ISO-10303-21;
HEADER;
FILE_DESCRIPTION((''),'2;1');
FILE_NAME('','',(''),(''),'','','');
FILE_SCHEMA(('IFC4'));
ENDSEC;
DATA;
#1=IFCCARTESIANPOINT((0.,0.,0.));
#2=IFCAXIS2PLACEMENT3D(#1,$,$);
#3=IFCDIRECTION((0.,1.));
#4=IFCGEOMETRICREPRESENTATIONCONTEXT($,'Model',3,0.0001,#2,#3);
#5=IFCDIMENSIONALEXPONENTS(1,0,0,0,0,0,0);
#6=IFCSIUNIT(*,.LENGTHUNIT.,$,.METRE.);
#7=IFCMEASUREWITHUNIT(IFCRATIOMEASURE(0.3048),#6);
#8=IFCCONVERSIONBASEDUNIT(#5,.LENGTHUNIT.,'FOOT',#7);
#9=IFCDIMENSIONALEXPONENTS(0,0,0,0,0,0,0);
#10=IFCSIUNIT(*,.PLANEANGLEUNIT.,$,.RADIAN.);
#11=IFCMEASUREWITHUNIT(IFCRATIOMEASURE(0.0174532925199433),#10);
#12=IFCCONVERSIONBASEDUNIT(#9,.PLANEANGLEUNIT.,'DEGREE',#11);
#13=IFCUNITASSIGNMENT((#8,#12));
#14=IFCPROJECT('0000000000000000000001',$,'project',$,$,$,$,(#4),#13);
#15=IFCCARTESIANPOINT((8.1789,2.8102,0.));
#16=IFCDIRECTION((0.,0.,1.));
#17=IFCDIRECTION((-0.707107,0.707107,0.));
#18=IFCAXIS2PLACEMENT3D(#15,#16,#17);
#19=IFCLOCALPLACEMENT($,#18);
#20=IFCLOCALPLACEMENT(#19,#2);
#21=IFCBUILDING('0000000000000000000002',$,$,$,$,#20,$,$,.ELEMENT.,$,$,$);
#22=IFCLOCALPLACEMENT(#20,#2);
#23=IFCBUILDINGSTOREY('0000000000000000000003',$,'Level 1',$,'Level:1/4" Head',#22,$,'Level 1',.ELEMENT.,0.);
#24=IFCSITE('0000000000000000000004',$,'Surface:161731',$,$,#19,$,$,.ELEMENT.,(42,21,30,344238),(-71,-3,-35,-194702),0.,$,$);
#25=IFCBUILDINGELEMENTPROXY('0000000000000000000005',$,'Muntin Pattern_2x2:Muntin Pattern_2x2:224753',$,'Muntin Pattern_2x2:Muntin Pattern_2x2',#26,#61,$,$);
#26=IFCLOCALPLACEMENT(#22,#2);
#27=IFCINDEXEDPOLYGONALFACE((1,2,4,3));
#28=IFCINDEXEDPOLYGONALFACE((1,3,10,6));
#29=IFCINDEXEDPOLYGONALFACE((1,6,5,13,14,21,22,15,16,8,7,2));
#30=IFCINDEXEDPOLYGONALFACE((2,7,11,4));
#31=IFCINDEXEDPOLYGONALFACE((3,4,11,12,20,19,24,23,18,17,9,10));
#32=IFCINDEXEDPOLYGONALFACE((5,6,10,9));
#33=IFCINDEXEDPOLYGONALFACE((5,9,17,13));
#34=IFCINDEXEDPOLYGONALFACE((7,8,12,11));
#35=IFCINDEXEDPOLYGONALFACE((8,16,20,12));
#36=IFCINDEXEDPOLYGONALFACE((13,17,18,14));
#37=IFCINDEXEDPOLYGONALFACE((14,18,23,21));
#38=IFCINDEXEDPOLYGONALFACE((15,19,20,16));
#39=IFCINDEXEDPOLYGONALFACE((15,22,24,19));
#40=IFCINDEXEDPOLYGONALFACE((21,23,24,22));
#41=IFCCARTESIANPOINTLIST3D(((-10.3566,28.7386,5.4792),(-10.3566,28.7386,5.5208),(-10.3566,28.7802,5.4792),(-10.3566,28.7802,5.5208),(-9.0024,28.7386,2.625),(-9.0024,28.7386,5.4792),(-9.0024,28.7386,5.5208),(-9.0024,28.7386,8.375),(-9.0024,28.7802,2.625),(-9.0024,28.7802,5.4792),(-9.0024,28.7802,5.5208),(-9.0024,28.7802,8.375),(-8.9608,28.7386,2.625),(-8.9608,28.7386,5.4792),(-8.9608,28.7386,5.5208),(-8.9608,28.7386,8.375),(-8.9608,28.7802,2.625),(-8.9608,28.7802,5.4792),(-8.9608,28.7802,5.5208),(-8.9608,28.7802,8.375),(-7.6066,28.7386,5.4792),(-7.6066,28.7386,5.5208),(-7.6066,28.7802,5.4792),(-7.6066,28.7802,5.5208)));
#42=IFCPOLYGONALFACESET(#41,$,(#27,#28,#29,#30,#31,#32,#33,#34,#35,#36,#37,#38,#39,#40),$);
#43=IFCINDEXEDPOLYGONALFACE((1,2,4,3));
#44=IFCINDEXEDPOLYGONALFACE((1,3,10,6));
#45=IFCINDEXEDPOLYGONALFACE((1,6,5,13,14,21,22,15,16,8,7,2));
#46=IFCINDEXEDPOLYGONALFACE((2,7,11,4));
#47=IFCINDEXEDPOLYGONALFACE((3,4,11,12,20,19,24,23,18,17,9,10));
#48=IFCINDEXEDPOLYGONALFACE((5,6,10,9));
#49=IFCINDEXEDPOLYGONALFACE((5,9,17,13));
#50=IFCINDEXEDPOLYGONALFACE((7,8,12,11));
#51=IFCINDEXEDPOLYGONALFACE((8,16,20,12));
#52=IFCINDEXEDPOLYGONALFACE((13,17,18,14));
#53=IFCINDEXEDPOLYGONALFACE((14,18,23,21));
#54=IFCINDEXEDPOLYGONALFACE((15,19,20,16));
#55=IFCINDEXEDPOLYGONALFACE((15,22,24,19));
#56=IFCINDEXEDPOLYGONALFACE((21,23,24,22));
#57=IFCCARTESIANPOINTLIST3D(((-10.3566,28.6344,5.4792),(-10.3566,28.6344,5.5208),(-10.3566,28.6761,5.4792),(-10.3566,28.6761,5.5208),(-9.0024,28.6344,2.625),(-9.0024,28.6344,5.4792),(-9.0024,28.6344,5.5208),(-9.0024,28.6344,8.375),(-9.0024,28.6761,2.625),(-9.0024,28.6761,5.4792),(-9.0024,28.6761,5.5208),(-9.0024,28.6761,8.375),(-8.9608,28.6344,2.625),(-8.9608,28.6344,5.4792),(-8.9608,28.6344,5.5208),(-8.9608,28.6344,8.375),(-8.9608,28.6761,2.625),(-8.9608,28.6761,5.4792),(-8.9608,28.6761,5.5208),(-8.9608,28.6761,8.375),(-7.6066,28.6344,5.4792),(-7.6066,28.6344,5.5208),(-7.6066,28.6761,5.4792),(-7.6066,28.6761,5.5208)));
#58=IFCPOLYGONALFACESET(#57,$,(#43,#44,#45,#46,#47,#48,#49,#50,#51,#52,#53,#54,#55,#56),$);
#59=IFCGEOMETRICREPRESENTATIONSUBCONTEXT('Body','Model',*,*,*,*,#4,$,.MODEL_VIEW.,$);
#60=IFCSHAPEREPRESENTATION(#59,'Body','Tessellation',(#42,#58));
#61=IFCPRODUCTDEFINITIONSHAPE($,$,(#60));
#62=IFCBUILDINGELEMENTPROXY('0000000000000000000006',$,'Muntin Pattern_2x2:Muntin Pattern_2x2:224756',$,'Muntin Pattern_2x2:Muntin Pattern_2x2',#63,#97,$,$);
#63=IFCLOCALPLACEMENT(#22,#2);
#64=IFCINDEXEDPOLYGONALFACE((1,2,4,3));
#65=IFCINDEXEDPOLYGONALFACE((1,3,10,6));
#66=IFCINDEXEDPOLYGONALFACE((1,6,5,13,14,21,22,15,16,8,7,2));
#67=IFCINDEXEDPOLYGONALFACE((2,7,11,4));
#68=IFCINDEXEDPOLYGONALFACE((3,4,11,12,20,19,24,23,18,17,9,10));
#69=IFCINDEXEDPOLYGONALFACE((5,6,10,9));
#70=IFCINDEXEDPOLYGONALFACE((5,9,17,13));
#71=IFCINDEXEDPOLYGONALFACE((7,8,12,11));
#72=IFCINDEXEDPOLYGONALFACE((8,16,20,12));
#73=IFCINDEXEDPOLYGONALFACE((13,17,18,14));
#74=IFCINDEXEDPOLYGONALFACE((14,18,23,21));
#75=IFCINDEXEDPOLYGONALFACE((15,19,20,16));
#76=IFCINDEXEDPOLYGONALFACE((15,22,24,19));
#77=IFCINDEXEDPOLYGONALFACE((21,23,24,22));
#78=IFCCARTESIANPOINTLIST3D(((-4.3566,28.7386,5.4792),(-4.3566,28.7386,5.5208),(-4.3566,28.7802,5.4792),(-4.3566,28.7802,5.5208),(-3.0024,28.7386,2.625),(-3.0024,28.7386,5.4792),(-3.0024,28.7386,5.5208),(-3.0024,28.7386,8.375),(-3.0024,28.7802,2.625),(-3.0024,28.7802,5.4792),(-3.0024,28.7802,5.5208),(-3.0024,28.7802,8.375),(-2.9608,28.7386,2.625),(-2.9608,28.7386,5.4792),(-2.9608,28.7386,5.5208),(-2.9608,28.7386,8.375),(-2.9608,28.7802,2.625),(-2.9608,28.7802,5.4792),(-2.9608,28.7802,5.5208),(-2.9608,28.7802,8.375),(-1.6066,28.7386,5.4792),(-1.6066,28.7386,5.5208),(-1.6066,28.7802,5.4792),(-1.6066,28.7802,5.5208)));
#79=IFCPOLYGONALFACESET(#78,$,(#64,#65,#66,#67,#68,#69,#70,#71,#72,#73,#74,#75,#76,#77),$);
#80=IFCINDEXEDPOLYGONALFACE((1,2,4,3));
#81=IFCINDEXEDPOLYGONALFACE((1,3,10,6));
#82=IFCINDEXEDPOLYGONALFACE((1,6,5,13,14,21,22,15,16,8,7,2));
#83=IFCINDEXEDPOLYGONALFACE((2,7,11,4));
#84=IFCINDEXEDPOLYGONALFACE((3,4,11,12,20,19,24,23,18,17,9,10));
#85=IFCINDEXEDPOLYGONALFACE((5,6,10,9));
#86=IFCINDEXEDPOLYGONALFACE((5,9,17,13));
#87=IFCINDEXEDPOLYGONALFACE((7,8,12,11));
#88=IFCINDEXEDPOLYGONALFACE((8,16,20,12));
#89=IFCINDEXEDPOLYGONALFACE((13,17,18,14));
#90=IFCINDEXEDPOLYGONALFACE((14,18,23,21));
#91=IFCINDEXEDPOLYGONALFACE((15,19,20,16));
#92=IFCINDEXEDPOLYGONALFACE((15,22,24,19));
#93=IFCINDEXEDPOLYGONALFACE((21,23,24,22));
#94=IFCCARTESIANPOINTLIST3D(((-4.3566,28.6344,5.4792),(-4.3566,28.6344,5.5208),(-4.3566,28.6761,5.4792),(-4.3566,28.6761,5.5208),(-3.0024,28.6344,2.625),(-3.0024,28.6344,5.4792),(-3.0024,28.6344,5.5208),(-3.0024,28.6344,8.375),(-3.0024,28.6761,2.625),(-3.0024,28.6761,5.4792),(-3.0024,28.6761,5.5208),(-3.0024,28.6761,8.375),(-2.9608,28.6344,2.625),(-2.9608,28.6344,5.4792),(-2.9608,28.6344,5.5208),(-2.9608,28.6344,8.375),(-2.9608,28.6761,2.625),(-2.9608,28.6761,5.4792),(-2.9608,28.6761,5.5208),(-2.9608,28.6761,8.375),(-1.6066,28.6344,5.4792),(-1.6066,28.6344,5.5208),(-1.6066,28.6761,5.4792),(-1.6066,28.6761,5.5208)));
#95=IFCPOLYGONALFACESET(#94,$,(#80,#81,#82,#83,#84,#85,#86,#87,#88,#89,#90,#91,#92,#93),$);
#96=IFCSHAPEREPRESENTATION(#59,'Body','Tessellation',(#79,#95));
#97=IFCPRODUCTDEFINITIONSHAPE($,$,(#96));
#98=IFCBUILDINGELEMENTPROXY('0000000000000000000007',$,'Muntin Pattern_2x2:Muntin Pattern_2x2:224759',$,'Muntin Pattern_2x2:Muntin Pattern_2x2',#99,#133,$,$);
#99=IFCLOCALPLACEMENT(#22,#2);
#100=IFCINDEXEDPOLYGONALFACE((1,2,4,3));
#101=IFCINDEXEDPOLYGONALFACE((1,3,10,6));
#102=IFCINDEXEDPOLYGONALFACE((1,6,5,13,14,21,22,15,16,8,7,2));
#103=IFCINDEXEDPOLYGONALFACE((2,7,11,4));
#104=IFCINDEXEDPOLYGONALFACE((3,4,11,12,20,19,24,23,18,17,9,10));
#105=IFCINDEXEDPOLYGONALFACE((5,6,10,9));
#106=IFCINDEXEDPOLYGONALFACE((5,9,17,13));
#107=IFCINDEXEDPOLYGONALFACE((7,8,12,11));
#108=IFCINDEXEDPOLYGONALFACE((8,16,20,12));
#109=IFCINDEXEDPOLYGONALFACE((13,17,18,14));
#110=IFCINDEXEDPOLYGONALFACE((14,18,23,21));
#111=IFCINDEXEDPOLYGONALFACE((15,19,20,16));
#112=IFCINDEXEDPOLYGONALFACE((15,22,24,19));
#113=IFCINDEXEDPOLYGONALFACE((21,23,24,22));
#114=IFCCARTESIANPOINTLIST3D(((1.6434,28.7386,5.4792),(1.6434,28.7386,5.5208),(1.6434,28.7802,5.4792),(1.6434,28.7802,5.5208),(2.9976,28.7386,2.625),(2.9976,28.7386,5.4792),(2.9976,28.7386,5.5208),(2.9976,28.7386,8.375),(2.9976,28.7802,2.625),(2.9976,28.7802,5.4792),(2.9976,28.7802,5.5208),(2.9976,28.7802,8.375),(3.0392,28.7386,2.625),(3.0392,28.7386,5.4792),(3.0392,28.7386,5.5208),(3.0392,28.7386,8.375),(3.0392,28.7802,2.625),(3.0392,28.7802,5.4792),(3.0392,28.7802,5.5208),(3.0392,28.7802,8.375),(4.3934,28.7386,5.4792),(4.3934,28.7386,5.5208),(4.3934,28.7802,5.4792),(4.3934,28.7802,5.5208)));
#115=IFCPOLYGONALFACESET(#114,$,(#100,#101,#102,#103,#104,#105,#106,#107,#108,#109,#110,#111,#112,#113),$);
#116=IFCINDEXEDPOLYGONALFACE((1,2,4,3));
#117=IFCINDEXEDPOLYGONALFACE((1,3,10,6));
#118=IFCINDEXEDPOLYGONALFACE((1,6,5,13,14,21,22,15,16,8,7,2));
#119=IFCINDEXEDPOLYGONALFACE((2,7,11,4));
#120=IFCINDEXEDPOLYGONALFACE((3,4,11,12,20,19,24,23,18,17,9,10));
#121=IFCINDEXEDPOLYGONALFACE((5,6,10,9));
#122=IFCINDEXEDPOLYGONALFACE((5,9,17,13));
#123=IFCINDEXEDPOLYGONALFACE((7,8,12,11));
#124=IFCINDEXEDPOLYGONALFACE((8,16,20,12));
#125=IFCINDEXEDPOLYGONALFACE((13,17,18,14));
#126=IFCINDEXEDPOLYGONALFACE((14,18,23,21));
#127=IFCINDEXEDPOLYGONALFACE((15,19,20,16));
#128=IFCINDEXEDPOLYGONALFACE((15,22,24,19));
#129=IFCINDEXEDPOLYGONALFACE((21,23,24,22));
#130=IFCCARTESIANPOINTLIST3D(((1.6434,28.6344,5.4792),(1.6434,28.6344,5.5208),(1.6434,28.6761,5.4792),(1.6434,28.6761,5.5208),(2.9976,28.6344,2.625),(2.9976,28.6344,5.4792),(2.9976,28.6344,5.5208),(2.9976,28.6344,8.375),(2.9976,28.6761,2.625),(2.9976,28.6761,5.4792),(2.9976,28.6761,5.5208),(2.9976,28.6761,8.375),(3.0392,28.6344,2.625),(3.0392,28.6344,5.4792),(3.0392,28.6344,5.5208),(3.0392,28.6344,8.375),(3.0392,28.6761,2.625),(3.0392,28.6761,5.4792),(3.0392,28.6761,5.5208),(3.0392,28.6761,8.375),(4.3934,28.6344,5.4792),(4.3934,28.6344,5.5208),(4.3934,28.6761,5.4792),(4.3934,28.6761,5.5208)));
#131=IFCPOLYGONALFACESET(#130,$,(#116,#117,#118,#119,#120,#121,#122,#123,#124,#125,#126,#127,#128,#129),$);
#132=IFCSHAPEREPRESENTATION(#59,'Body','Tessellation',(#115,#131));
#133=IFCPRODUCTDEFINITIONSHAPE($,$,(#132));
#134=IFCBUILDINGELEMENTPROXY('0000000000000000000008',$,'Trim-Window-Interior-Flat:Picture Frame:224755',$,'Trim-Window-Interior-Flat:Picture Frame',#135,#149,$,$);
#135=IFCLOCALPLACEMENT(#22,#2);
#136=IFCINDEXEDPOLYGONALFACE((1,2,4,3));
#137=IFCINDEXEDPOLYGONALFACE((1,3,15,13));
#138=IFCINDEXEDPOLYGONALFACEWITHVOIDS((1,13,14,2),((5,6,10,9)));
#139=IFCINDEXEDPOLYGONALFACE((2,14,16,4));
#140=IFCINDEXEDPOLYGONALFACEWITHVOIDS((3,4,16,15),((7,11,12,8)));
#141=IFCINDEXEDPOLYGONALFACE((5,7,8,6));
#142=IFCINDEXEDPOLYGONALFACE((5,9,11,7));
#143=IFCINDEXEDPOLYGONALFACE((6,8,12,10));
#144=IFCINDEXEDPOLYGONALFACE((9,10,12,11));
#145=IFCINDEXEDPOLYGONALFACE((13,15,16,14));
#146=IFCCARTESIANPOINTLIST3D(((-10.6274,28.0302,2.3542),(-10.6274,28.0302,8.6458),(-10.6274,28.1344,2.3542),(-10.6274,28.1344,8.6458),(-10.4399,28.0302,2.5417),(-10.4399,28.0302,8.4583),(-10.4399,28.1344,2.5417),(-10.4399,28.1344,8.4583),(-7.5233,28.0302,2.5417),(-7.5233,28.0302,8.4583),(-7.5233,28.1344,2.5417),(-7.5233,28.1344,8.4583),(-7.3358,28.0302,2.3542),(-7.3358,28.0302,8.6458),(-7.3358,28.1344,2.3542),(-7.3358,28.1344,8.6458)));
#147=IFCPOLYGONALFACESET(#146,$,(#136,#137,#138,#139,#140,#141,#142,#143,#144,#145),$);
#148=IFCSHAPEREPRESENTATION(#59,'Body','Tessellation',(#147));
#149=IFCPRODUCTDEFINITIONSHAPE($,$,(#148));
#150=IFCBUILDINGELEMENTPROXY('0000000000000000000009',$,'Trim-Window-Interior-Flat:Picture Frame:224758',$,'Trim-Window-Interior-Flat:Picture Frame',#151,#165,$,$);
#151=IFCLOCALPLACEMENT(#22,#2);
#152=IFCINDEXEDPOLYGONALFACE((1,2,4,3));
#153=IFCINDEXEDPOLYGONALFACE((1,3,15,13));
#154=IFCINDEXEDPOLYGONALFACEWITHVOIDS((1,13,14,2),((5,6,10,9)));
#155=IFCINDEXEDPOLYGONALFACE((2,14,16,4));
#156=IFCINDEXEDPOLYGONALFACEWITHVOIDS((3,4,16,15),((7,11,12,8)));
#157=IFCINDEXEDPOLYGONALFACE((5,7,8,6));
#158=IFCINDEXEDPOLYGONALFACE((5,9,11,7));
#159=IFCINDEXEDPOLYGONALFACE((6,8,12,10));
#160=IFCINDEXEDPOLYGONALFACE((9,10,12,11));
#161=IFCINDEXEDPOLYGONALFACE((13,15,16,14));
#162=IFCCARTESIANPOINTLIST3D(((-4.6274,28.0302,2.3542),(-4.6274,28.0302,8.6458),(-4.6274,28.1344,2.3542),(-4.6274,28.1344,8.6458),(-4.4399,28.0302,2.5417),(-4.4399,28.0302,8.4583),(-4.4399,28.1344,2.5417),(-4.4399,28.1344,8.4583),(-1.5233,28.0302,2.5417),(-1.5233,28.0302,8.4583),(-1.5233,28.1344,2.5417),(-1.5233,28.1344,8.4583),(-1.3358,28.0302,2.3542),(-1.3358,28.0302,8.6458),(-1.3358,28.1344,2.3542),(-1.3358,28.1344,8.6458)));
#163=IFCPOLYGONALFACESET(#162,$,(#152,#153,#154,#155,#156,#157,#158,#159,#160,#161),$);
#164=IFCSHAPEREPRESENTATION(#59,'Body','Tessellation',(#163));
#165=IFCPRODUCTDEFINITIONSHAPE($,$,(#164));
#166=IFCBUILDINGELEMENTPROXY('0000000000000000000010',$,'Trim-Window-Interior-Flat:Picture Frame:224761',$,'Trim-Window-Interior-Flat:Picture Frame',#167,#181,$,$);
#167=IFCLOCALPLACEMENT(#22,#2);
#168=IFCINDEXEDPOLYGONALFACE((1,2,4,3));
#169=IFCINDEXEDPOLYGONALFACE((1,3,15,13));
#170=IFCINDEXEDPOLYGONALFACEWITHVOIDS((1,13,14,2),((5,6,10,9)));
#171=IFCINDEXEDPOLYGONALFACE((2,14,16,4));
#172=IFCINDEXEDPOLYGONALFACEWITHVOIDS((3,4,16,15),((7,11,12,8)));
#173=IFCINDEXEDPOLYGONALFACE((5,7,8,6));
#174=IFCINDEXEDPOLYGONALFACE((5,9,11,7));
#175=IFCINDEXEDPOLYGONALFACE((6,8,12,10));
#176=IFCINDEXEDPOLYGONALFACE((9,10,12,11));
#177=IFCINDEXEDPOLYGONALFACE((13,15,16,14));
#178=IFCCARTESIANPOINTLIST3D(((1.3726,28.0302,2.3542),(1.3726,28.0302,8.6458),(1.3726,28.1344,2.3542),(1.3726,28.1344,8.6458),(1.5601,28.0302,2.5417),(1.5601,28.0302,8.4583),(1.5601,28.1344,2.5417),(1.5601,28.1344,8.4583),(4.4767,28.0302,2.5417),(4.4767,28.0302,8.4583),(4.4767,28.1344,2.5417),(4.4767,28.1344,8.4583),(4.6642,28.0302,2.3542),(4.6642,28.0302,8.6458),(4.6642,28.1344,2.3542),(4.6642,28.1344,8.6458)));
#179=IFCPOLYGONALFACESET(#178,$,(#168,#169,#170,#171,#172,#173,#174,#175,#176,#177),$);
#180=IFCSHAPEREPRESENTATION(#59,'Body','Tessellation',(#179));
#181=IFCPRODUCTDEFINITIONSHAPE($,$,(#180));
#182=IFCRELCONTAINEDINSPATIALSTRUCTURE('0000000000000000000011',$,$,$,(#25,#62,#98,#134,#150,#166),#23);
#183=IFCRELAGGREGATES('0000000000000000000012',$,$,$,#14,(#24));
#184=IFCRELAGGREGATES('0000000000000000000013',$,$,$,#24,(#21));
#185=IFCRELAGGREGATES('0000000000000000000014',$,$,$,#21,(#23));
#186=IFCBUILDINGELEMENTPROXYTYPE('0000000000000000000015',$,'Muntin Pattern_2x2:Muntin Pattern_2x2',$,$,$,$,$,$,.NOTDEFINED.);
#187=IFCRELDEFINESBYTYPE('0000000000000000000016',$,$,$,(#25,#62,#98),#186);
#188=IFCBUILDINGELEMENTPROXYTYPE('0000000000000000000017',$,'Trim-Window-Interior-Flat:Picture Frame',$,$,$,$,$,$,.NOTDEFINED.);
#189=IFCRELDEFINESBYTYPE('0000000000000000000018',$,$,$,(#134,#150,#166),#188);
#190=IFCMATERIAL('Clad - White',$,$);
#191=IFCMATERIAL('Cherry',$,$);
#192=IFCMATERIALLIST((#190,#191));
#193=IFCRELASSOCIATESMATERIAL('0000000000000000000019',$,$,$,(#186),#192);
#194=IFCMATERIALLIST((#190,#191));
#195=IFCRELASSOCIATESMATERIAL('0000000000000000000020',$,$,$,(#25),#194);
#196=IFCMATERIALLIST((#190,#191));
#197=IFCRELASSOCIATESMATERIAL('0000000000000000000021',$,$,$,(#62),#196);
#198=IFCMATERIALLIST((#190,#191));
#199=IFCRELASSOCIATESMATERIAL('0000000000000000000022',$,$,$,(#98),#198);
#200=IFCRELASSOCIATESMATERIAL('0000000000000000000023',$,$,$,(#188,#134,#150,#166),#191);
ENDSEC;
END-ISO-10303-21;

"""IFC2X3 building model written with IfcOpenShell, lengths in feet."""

from ifc_helpers import new_model, entity, si_unit, converted_unit, direction, frame, origin, place, context, subcontext, project, spatial, polyline, outline, extrude, source, transform, mapped, material, material_list, type_object, type_shapes, element, save


model = new_model("IFC2X3")

# Units and contexts
model_context = context("Model", 3, precision=0.0001, world=origin(), true_north=direction((0.0, 1.0)))
body_context = subcontext(model_context, "Body", "Model", "MODEL_VIEW")
ifc_project = project(units=[converted_unit("LENGTHUNIT", "FOOT", entity("IfcRatioMeasure", 0.3048), si_unit("LENGTHUNIT", "METRE"), dimensions=[1, 0, 0, 0, 0, 0, 0]), converted_unit("PLANEANGLEUNIT", "DEGREE", entity("IfcRatioMeasure", 0.0174532925199433), si_unit("PLANEANGLEUNIT", "RADIAN"), dimensions=[0, 0, 0, 0, 0, 0, 0])], contexts=[model_context])

# Site, building, storey
site_placement = place(None, frame((8.1789, 2.8102, 0.0), z_axis=(0.0, 0.0, 1.0), x_axis=(-0.707107, 0.707107, 0.0)))
site = spatial("IfcSite", under=ifc_project, at=site_placement, Name="Surface:161731", CompositionType="ELEMENT", RefLatitude=(42, 21, 30, 344238), RefLongitude=(-71, -3, -35, -194702), RefElevation=0.0)
building_placement = place(site_placement, origin())
building = spatial("IfcBuilding", under=site, at=building_placement, CompositionType="ELEMENT")
storey_placement = place(building_placement, origin())
storey = spatial("IfcBuildingStorey", under=building, at=storey_placement, Name="Level 1", ObjectType="Level:1/4\" Head", LongName="Level 1", CompositionType="ELEMENT", Elevation=0.0)

# Building element proxies
ifc_material_1 = material(Name="Clad - White")
ifc_material_2 = material(Name="Cherry")
ifc_material_list_1 = material_list([ifc_material_1, ifc_material_2])
ifc_material_list_2 = material_list([ifc_material_1, ifc_material_2])
building_element_proxy_type_1 = type_object("IfcBuildingElementProxyType", Name="Muntin Pattern_2x2:Muntin Pattern_2x2", PredefinedType="NOTDEFINED", material=ifc_material_list_2)
shared_shape_1 = source(origin(), body_context, "Body", "SweptSolid", [
    extrude(outline(polyline([(0.0208, -0.0208), (2.875, -0.0208), (2.875, 0.0208), (0.0208, 0.0208), (0.0208, 1.375), (-0.0208, 1.375), (-0.0208, 0.0208), (-2.875, 0.0208), (-2.875, -0.0208), (-0.0208, -0.0208), (-0.0208, -1.375), (0.0208, -1.375), (0.0208, -0.0208)])), frame((0.0, -0.0729, 2.875), z_axis=(0.0, 1.0, 0.0), x_axis=(0.0, 0.0, 1.0)), (0.0, 0.0, 1.0), 0.0417),
    extrude(outline(polyline([(0.0208, -0.0208), (2.875, -0.0208), (2.875, 0.0208), (0.0208, 0.0208), (0.0208, 1.375), (-0.0208, 1.375), (-0.0208, 0.0208), (-2.875, 0.0208), (-2.875, -0.0208), (-0.0208, -0.0208), (-0.0208, -1.375), (0.0208, -1.375), (0.0208, -0.0208)])), frame((0.0, 0.0313, 2.875), z_axis=(0.0, 1.0, 0.0), x_axis=(0.0, 0.0, 1.0)), (0.0, 0.0, 1.0), 0.0417),
])
type_shapes(building_element_proxy_type_1, [shared_shape_1])
proxy_1_placement = place(storey_placement, frame((-8.9816, 28.7073, 2.625), z_axis=(0.0, 0.0, 1.0), x_axis=(-1.0, 0.0, 0.0)))
element("IfcBuildingElementProxy", 1, at=proxy_1_placement, inside=storey, type_object=building_element_proxy_type_1, material=ifc_material_list_1, Name="Muntin Pattern_2x2:Muntin Pattern_2x2:224753", ObjectType="Muntin Pattern_2x2:Muntin Pattern_2x2", context=body_context, shape_type="MappedRepresentation", body=[
    mapped(shared_shape_1, transform((0.0, 0.0, 0.0), scale=1.0)),
])
ifc_material_list_3 = material_list([ifc_material_1, ifc_material_2])
proxy_2_placement = place(storey_placement, frame((-2.9816, 28.7073, 2.625), z_axis=(0.0, 0.0, 1.0), x_axis=(-1.0, 0.0, 0.0)))
element("IfcBuildingElementProxy", 2, at=proxy_2_placement, inside=storey, type_object=building_element_proxy_type_1, material=ifc_material_list_3, Name="Muntin Pattern_2x2:Muntin Pattern_2x2:224756", ObjectType="Muntin Pattern_2x2:Muntin Pattern_2x2", context=body_context, shape_type="MappedRepresentation", body=[
    mapped(shared_shape_1, transform((0.0, 0.0, 0.0), scale=1.0)),
])
ifc_material_list_4 = material_list([ifc_material_1, ifc_material_2])
proxy_3_placement = place(storey_placement, frame((3.0184, 28.7073, 2.625), z_axis=(0.0, 0.0, 1.0), x_axis=(-1.0, 0.0, 0.0)))
element("IfcBuildingElementProxy", 3, at=proxy_3_placement, inside=storey, type_object=building_element_proxy_type_1, material=ifc_material_list_4, Name="Muntin Pattern_2x2:Muntin Pattern_2x2:224759", ObjectType="Muntin Pattern_2x2:Muntin Pattern_2x2", context=body_context, shape_type="MappedRepresentation", body=[
    mapped(shared_shape_1, transform((0.0, 0.0, 0.0), scale=1.0)),
])
building_element_proxy_type_2 = type_object("IfcBuildingElementProxyType", Name="Trim-Window-Interior-Flat:Picture Frame", PredefinedType="NOTDEFINED", material=ifc_material_2)
shared_shape_2 = source(origin(), body_context, "Body", "SweptSolid", [
    extrude(outline(polyline([(-1.6458, -3.1458), (1.6458, -3.1458), (1.6458, 3.1458), (-1.6458, 3.1458), (-1.6458, -3.1458)]), holes=[polyline([(-1.4583, -2.9583), (-1.4583, 2.9583), (1.4583, 2.9583), (1.4583, -2.9583), (-1.4583, -2.9583)])]), frame((0.0, -3.0, 0.0), z_axis=(0.0, 0.0, 1.0), x_axis=(-1.0, 0.0, 0.0)), (0.0, 0.0, 1.0), 0.1042),
])
type_shapes(building_element_proxy_type_2, [shared_shape_2])
for number, where, z_axis, x_axis, name in (
    (4, (-8.9816, 28.1344, 8.5), (0.0, -1.0, 0.0), (1.0, 0.0, 0.0), "Trim-Window-Interior-Flat:Picture Frame:224755"),
    (5, (-2.9816, 28.1344, 8.5), (0.0, -1.0, 0.0), (1.0, 0.0, 0.0), "Trim-Window-Interior-Flat:Picture Frame:224758"),
    (6, (3.0184, 28.1344, 8.5), (0.0, -1.0, 0.0), (1.0, 0.0, 0.0), "Trim-Window-Interior-Flat:Picture Frame:224761"),
):
    element("IfcBuildingElementProxy", number, at=place(storey_placement, frame(where, z_axis=z_axis, x_axis=x_axis)), inside=storey, type_object=building_element_proxy_type_2, material=ifc_material_2, Name=name, ObjectType="Trim-Window-Interior-Flat:Picture Frame", context=body_context, shape_type="MappedRepresentation", body=[
        mapped(shared_shape_2, transform((0.0, 0.0, 0.0), scale=1.0)),
    ])

save(model, "model.ifc")
